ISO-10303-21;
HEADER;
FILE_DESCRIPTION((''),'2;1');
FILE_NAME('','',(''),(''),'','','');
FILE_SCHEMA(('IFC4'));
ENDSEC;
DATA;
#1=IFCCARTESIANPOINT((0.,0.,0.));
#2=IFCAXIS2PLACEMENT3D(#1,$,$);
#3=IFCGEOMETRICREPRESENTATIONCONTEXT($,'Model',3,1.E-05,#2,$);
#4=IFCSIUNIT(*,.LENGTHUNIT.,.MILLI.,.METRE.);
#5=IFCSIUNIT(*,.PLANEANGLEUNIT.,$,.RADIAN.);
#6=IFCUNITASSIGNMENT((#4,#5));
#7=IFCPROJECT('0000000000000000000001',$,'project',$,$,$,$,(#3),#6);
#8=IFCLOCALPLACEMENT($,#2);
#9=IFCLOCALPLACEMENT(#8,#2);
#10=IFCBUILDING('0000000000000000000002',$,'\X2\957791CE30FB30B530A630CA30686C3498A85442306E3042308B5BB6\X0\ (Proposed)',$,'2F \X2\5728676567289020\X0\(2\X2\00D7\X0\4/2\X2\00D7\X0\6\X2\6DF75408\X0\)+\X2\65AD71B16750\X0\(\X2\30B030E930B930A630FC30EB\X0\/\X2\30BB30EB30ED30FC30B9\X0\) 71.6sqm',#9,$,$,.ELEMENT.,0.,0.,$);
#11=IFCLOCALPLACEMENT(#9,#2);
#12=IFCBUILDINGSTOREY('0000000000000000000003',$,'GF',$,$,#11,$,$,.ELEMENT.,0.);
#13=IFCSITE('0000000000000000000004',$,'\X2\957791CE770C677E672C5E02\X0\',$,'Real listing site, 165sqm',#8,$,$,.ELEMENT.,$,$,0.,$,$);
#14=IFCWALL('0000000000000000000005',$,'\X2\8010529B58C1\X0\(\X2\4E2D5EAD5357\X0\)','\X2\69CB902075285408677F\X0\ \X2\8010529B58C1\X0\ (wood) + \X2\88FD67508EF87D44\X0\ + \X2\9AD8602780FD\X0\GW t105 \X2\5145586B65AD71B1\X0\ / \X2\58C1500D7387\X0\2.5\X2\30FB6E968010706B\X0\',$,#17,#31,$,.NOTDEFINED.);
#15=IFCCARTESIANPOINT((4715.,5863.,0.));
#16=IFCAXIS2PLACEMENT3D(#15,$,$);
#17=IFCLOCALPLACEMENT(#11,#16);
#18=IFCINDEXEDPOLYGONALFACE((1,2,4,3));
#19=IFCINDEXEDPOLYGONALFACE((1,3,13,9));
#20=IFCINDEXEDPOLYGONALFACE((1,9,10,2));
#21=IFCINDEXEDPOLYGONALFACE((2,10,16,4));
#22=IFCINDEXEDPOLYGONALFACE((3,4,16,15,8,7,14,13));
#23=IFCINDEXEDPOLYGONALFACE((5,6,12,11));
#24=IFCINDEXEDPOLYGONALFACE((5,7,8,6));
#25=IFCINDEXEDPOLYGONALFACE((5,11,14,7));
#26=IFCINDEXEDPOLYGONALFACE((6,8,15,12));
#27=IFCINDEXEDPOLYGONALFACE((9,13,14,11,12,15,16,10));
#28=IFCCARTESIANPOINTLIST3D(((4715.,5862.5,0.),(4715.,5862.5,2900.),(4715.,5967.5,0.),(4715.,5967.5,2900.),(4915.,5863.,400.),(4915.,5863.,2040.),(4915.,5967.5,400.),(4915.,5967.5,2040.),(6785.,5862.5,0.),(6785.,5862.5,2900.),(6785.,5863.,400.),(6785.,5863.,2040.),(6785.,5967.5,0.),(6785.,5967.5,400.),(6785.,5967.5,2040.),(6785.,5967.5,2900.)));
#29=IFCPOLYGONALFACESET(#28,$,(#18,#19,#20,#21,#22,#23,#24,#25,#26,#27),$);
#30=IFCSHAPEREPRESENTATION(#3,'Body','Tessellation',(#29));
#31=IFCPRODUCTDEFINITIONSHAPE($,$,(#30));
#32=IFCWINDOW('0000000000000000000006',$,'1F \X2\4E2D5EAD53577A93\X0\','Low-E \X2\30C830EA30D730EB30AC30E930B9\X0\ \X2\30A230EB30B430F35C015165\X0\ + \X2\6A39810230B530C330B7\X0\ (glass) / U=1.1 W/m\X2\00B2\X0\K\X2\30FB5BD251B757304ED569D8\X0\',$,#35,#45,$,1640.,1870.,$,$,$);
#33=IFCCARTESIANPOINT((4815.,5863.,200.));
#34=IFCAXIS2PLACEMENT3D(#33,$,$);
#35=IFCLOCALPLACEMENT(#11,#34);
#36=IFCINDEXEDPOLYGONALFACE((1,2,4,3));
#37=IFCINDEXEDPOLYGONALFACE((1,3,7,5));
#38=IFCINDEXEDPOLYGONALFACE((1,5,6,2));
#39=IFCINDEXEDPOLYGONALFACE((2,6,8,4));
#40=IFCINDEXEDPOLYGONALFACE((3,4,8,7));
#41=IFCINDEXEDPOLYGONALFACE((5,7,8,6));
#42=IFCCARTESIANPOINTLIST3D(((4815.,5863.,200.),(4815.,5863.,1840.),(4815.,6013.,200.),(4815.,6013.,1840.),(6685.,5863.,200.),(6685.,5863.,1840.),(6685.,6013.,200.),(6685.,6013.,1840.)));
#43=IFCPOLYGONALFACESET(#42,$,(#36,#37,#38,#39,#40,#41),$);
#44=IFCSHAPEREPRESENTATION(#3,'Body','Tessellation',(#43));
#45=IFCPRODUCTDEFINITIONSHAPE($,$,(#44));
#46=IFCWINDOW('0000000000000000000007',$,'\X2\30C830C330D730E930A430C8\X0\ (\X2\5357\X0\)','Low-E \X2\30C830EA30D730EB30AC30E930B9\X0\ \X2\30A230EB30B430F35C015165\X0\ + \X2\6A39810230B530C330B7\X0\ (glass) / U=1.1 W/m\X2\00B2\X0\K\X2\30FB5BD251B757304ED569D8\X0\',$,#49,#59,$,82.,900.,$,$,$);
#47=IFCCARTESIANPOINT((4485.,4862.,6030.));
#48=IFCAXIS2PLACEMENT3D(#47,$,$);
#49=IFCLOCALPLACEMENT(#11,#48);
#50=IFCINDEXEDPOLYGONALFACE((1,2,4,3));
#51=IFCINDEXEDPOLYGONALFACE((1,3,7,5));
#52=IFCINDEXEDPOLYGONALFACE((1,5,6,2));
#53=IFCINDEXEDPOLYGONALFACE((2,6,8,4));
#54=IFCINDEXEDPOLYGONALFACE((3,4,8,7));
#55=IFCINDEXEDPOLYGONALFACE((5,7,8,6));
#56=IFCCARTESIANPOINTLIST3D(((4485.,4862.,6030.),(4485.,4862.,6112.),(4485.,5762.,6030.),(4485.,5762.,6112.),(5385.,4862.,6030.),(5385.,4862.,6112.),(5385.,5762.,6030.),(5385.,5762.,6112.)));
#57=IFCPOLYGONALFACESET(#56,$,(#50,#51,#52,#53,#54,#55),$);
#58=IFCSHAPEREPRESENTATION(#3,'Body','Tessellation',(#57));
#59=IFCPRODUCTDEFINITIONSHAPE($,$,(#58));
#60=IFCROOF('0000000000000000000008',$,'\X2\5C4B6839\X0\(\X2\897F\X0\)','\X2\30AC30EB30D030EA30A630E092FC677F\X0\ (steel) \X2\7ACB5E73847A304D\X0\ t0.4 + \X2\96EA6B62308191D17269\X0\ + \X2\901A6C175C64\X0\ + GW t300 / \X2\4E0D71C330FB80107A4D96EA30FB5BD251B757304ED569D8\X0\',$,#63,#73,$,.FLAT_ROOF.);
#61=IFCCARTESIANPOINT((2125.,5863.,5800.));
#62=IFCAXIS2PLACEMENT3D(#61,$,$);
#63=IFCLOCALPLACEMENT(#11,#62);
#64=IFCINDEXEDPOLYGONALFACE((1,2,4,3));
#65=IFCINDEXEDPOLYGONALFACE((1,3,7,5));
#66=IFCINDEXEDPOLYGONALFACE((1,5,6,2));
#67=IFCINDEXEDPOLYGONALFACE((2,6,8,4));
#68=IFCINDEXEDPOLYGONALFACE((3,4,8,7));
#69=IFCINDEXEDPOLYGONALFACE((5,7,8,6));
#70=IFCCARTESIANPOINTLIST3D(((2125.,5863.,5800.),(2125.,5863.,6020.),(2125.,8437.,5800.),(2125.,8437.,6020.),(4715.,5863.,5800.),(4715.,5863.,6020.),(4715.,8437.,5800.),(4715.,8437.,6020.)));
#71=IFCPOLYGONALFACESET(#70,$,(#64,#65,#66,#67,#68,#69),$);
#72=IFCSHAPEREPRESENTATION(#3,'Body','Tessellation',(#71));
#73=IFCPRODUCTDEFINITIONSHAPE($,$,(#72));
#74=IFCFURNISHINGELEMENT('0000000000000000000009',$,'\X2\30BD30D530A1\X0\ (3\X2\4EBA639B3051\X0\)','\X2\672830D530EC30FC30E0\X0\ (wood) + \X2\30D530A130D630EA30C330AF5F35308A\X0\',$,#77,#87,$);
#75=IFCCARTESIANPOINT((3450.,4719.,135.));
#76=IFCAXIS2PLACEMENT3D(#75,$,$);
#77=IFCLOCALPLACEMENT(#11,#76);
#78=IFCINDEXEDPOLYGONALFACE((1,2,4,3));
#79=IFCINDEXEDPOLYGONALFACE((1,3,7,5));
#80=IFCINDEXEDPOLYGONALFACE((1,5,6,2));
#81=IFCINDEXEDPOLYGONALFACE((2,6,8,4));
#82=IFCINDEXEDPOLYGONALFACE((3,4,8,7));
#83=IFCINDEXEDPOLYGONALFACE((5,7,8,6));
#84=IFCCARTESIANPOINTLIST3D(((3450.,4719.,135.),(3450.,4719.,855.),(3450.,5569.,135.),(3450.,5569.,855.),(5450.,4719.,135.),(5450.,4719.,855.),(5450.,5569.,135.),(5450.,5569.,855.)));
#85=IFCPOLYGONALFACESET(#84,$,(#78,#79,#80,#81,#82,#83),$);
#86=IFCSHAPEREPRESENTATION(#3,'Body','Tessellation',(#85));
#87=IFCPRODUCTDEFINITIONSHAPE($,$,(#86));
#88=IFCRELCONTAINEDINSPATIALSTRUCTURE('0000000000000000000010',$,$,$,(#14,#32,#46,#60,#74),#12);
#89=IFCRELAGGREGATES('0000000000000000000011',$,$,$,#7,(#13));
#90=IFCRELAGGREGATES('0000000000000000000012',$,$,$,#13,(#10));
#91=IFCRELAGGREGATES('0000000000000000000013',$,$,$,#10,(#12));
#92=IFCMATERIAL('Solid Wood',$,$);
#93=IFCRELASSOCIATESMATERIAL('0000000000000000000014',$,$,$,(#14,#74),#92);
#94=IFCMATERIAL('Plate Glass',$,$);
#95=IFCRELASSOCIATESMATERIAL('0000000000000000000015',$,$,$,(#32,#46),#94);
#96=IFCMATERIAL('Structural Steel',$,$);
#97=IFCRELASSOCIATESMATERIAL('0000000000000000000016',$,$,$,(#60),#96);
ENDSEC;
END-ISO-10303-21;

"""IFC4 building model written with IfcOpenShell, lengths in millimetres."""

from ifc_helpers import new_model, si_unit, frame, frame_2d, origin, place, context, project, spatial, rectangle, extrude, material, element, fill, save


model = new_model("IFC4")

# Units and contexts
model_context = context("Model", 3, precision=1e-05, world=origin())
ifc_project = project(units=[si_unit("LENGTHUNIT", "METRE", prefix="MILLI"), si_unit("PLANEANGLEUNIT", "RADIAN")], contexts=[model_context])

# Site, building, storey
site_placement = place(None, origin())
site = spatial("IfcSite", under=ifc_project, at=site_placement, Name="長野県松本市", ObjectType="Real listing site, 165sqm", CompositionType="ELEMENT", RefElevation=0.0)
building_placement = place(site_placement, origin())
building = spatial("IfcBuilding", under=site, at=building_placement, Name="長野・サウナと水風呂のある家 (Proposed)", ObjectType="2F 在来木造(2×4/2×6混合)+断熱材(グラスウール/セルロース) 71.6sqm", CompositionType="ELEMENT", ElevationOfRefHeight=0.0, ElevationOfTerrain=0.0)
storey_placement = place(building_placement, origin())
storey = spatial("IfcBuildingStorey", under=building, at=storey_placement, Name="GF", CompositionType="ELEMENT", Elevation=0.0)

# Shared definitions
ifc_material_1 = material(Name="Solid Wood")

# Wall, opening, window
wall_1_placement = place(storey_placement, frame((4715.0, 5863.0, 0.0)))
wall_1 = element("IfcWall", 1, at=wall_1_placement, inside=storey, material=ifc_material_1, Name="耐力壁(中庭南)", Description="構造用合板 耐力壁 (wood) + 製材軸組 + 高性能GW t105 充填断熱 / 壁倍率2.5・準耐火", PredefinedType="NOTDEFINED", context=model_context, shape_type="SweptSolid", body=[
    extrude(rectangle(XDim=2070.0, YDim=105.0, at=frame_2d((1035.0, 52.0))), frame((4715.0, 5863.0, 0.0)), (0.0, 0.0, 1.0), 2900.0),
])
opening_placement = place(storey_placement, frame((4815.0, 5863.0, 200.0)))
opening = element("IfcOpeningElement", 2, at=opening_placement, cuts=wall_1, PredefinedType="NOTDEFINED", context=model_context, shape_type="SweptSolid", body=[
    extrude(rectangle(XDim=1870.0, YDim=150.0, at=frame_2d((935.0, 75.0))), frame((4815.0, 5863.0, 200.0)), (0.0, 0.0, 1.0), 1640.0),
])
ifc_material_2 = material(Name="Plate Glass")
window_1_placement = place(storey_placement, frame((4815.0, 5863.0, 200.0)))
window_1 = element("IfcWindow", 3, at=window_1_placement, inside=storey, material=ifc_material_2, Name="1F 中庭南窓", Description="Low-E トリプルガラス アルゴン封入 + 樹脂サッシ (glass) / U=1.1 W/m²K・寒冷地仕様", OverallHeight=1640.0, OverallWidth=1870.0, context=model_context, shape_type="SweptSolid", body=[
    extrude(rectangle(XDim=1870.0, YDim=150.0, at=frame_2d((935.0, 75.0))), frame((4815.0, 5863.0, 200.0)), (0.0, 0.0, 1.0), 1640.0),
])
fill(opening, window_1)

# Window
window_2_placement = place(storey_placement, frame((4485.0, 4862.0, 6030.0)))
element("IfcWindow", 4, at=window_2_placement, inside=storey, material=ifc_material_2, Name="トップライト (南)", Description="Low-E トリプルガラス アルゴン封入 + 樹脂サッシ (glass) / U=1.1 W/m²K・寒冷地仕様", OverallHeight=82.0, OverallWidth=900.0, context=model_context, shape_type="SweptSolid", body=[
    extrude(rectangle(XDim=900.0, YDim=900.0, at=frame_2d((450.0, 450.0))), frame((4485.0, 4862.0, 6030.0)), (0.0, 0.0, 1.0), 82.0),
])

# Roof
ifc_material_3 = material(Name="Structural Steel")
for number, where, name in (
    (5, (2125.0, 5863.0, 5800.0), "屋根(西)"),
):
    element("IfcRoof", number, at=place(storey_placement, frame(where)), inside=storey, material=ifc_material_3, Name=name, Description="ガルバリウム鋼板 (steel) 立平葺き t0.4 + 雪止め金物 + 通気層 + GW t300 / 不燃・耐積雪・寒冷地仕様", PredefinedType="FLAT_ROOF", context=model_context, shape_type="SweptSolid", body=[
        extrude(rectangle(XDim=2590.0, YDim=2574.0, at=frame_2d((1295.0, 1287.0))), frame((2125.0, 5863.0, 5800.0)), (0.0, 0.0, 1.0), 220.0),
    ])

# Furnishing element
furnishing_placement = place(storey_placement, frame((3450.0, 4719.0, 135.0)))
element("IfcFurnishingElement", 6, at=furnishing_placement, inside=storey, material=ifc_material_1, Name="ソファ (3人掛け)", Description="木フレーム (wood) + ファブリック張り", context=model_context, shape_type="SweptSolid", body=[
    extrude(rectangle(XDim=2000.0, YDim=850.0, at=frame_2d((1000.0, 425.0))), frame((3450.0, 4719.0, 135.0)), (0.0, 0.0, 1.0), 720.0),
])

save(model, "model.ifc")
